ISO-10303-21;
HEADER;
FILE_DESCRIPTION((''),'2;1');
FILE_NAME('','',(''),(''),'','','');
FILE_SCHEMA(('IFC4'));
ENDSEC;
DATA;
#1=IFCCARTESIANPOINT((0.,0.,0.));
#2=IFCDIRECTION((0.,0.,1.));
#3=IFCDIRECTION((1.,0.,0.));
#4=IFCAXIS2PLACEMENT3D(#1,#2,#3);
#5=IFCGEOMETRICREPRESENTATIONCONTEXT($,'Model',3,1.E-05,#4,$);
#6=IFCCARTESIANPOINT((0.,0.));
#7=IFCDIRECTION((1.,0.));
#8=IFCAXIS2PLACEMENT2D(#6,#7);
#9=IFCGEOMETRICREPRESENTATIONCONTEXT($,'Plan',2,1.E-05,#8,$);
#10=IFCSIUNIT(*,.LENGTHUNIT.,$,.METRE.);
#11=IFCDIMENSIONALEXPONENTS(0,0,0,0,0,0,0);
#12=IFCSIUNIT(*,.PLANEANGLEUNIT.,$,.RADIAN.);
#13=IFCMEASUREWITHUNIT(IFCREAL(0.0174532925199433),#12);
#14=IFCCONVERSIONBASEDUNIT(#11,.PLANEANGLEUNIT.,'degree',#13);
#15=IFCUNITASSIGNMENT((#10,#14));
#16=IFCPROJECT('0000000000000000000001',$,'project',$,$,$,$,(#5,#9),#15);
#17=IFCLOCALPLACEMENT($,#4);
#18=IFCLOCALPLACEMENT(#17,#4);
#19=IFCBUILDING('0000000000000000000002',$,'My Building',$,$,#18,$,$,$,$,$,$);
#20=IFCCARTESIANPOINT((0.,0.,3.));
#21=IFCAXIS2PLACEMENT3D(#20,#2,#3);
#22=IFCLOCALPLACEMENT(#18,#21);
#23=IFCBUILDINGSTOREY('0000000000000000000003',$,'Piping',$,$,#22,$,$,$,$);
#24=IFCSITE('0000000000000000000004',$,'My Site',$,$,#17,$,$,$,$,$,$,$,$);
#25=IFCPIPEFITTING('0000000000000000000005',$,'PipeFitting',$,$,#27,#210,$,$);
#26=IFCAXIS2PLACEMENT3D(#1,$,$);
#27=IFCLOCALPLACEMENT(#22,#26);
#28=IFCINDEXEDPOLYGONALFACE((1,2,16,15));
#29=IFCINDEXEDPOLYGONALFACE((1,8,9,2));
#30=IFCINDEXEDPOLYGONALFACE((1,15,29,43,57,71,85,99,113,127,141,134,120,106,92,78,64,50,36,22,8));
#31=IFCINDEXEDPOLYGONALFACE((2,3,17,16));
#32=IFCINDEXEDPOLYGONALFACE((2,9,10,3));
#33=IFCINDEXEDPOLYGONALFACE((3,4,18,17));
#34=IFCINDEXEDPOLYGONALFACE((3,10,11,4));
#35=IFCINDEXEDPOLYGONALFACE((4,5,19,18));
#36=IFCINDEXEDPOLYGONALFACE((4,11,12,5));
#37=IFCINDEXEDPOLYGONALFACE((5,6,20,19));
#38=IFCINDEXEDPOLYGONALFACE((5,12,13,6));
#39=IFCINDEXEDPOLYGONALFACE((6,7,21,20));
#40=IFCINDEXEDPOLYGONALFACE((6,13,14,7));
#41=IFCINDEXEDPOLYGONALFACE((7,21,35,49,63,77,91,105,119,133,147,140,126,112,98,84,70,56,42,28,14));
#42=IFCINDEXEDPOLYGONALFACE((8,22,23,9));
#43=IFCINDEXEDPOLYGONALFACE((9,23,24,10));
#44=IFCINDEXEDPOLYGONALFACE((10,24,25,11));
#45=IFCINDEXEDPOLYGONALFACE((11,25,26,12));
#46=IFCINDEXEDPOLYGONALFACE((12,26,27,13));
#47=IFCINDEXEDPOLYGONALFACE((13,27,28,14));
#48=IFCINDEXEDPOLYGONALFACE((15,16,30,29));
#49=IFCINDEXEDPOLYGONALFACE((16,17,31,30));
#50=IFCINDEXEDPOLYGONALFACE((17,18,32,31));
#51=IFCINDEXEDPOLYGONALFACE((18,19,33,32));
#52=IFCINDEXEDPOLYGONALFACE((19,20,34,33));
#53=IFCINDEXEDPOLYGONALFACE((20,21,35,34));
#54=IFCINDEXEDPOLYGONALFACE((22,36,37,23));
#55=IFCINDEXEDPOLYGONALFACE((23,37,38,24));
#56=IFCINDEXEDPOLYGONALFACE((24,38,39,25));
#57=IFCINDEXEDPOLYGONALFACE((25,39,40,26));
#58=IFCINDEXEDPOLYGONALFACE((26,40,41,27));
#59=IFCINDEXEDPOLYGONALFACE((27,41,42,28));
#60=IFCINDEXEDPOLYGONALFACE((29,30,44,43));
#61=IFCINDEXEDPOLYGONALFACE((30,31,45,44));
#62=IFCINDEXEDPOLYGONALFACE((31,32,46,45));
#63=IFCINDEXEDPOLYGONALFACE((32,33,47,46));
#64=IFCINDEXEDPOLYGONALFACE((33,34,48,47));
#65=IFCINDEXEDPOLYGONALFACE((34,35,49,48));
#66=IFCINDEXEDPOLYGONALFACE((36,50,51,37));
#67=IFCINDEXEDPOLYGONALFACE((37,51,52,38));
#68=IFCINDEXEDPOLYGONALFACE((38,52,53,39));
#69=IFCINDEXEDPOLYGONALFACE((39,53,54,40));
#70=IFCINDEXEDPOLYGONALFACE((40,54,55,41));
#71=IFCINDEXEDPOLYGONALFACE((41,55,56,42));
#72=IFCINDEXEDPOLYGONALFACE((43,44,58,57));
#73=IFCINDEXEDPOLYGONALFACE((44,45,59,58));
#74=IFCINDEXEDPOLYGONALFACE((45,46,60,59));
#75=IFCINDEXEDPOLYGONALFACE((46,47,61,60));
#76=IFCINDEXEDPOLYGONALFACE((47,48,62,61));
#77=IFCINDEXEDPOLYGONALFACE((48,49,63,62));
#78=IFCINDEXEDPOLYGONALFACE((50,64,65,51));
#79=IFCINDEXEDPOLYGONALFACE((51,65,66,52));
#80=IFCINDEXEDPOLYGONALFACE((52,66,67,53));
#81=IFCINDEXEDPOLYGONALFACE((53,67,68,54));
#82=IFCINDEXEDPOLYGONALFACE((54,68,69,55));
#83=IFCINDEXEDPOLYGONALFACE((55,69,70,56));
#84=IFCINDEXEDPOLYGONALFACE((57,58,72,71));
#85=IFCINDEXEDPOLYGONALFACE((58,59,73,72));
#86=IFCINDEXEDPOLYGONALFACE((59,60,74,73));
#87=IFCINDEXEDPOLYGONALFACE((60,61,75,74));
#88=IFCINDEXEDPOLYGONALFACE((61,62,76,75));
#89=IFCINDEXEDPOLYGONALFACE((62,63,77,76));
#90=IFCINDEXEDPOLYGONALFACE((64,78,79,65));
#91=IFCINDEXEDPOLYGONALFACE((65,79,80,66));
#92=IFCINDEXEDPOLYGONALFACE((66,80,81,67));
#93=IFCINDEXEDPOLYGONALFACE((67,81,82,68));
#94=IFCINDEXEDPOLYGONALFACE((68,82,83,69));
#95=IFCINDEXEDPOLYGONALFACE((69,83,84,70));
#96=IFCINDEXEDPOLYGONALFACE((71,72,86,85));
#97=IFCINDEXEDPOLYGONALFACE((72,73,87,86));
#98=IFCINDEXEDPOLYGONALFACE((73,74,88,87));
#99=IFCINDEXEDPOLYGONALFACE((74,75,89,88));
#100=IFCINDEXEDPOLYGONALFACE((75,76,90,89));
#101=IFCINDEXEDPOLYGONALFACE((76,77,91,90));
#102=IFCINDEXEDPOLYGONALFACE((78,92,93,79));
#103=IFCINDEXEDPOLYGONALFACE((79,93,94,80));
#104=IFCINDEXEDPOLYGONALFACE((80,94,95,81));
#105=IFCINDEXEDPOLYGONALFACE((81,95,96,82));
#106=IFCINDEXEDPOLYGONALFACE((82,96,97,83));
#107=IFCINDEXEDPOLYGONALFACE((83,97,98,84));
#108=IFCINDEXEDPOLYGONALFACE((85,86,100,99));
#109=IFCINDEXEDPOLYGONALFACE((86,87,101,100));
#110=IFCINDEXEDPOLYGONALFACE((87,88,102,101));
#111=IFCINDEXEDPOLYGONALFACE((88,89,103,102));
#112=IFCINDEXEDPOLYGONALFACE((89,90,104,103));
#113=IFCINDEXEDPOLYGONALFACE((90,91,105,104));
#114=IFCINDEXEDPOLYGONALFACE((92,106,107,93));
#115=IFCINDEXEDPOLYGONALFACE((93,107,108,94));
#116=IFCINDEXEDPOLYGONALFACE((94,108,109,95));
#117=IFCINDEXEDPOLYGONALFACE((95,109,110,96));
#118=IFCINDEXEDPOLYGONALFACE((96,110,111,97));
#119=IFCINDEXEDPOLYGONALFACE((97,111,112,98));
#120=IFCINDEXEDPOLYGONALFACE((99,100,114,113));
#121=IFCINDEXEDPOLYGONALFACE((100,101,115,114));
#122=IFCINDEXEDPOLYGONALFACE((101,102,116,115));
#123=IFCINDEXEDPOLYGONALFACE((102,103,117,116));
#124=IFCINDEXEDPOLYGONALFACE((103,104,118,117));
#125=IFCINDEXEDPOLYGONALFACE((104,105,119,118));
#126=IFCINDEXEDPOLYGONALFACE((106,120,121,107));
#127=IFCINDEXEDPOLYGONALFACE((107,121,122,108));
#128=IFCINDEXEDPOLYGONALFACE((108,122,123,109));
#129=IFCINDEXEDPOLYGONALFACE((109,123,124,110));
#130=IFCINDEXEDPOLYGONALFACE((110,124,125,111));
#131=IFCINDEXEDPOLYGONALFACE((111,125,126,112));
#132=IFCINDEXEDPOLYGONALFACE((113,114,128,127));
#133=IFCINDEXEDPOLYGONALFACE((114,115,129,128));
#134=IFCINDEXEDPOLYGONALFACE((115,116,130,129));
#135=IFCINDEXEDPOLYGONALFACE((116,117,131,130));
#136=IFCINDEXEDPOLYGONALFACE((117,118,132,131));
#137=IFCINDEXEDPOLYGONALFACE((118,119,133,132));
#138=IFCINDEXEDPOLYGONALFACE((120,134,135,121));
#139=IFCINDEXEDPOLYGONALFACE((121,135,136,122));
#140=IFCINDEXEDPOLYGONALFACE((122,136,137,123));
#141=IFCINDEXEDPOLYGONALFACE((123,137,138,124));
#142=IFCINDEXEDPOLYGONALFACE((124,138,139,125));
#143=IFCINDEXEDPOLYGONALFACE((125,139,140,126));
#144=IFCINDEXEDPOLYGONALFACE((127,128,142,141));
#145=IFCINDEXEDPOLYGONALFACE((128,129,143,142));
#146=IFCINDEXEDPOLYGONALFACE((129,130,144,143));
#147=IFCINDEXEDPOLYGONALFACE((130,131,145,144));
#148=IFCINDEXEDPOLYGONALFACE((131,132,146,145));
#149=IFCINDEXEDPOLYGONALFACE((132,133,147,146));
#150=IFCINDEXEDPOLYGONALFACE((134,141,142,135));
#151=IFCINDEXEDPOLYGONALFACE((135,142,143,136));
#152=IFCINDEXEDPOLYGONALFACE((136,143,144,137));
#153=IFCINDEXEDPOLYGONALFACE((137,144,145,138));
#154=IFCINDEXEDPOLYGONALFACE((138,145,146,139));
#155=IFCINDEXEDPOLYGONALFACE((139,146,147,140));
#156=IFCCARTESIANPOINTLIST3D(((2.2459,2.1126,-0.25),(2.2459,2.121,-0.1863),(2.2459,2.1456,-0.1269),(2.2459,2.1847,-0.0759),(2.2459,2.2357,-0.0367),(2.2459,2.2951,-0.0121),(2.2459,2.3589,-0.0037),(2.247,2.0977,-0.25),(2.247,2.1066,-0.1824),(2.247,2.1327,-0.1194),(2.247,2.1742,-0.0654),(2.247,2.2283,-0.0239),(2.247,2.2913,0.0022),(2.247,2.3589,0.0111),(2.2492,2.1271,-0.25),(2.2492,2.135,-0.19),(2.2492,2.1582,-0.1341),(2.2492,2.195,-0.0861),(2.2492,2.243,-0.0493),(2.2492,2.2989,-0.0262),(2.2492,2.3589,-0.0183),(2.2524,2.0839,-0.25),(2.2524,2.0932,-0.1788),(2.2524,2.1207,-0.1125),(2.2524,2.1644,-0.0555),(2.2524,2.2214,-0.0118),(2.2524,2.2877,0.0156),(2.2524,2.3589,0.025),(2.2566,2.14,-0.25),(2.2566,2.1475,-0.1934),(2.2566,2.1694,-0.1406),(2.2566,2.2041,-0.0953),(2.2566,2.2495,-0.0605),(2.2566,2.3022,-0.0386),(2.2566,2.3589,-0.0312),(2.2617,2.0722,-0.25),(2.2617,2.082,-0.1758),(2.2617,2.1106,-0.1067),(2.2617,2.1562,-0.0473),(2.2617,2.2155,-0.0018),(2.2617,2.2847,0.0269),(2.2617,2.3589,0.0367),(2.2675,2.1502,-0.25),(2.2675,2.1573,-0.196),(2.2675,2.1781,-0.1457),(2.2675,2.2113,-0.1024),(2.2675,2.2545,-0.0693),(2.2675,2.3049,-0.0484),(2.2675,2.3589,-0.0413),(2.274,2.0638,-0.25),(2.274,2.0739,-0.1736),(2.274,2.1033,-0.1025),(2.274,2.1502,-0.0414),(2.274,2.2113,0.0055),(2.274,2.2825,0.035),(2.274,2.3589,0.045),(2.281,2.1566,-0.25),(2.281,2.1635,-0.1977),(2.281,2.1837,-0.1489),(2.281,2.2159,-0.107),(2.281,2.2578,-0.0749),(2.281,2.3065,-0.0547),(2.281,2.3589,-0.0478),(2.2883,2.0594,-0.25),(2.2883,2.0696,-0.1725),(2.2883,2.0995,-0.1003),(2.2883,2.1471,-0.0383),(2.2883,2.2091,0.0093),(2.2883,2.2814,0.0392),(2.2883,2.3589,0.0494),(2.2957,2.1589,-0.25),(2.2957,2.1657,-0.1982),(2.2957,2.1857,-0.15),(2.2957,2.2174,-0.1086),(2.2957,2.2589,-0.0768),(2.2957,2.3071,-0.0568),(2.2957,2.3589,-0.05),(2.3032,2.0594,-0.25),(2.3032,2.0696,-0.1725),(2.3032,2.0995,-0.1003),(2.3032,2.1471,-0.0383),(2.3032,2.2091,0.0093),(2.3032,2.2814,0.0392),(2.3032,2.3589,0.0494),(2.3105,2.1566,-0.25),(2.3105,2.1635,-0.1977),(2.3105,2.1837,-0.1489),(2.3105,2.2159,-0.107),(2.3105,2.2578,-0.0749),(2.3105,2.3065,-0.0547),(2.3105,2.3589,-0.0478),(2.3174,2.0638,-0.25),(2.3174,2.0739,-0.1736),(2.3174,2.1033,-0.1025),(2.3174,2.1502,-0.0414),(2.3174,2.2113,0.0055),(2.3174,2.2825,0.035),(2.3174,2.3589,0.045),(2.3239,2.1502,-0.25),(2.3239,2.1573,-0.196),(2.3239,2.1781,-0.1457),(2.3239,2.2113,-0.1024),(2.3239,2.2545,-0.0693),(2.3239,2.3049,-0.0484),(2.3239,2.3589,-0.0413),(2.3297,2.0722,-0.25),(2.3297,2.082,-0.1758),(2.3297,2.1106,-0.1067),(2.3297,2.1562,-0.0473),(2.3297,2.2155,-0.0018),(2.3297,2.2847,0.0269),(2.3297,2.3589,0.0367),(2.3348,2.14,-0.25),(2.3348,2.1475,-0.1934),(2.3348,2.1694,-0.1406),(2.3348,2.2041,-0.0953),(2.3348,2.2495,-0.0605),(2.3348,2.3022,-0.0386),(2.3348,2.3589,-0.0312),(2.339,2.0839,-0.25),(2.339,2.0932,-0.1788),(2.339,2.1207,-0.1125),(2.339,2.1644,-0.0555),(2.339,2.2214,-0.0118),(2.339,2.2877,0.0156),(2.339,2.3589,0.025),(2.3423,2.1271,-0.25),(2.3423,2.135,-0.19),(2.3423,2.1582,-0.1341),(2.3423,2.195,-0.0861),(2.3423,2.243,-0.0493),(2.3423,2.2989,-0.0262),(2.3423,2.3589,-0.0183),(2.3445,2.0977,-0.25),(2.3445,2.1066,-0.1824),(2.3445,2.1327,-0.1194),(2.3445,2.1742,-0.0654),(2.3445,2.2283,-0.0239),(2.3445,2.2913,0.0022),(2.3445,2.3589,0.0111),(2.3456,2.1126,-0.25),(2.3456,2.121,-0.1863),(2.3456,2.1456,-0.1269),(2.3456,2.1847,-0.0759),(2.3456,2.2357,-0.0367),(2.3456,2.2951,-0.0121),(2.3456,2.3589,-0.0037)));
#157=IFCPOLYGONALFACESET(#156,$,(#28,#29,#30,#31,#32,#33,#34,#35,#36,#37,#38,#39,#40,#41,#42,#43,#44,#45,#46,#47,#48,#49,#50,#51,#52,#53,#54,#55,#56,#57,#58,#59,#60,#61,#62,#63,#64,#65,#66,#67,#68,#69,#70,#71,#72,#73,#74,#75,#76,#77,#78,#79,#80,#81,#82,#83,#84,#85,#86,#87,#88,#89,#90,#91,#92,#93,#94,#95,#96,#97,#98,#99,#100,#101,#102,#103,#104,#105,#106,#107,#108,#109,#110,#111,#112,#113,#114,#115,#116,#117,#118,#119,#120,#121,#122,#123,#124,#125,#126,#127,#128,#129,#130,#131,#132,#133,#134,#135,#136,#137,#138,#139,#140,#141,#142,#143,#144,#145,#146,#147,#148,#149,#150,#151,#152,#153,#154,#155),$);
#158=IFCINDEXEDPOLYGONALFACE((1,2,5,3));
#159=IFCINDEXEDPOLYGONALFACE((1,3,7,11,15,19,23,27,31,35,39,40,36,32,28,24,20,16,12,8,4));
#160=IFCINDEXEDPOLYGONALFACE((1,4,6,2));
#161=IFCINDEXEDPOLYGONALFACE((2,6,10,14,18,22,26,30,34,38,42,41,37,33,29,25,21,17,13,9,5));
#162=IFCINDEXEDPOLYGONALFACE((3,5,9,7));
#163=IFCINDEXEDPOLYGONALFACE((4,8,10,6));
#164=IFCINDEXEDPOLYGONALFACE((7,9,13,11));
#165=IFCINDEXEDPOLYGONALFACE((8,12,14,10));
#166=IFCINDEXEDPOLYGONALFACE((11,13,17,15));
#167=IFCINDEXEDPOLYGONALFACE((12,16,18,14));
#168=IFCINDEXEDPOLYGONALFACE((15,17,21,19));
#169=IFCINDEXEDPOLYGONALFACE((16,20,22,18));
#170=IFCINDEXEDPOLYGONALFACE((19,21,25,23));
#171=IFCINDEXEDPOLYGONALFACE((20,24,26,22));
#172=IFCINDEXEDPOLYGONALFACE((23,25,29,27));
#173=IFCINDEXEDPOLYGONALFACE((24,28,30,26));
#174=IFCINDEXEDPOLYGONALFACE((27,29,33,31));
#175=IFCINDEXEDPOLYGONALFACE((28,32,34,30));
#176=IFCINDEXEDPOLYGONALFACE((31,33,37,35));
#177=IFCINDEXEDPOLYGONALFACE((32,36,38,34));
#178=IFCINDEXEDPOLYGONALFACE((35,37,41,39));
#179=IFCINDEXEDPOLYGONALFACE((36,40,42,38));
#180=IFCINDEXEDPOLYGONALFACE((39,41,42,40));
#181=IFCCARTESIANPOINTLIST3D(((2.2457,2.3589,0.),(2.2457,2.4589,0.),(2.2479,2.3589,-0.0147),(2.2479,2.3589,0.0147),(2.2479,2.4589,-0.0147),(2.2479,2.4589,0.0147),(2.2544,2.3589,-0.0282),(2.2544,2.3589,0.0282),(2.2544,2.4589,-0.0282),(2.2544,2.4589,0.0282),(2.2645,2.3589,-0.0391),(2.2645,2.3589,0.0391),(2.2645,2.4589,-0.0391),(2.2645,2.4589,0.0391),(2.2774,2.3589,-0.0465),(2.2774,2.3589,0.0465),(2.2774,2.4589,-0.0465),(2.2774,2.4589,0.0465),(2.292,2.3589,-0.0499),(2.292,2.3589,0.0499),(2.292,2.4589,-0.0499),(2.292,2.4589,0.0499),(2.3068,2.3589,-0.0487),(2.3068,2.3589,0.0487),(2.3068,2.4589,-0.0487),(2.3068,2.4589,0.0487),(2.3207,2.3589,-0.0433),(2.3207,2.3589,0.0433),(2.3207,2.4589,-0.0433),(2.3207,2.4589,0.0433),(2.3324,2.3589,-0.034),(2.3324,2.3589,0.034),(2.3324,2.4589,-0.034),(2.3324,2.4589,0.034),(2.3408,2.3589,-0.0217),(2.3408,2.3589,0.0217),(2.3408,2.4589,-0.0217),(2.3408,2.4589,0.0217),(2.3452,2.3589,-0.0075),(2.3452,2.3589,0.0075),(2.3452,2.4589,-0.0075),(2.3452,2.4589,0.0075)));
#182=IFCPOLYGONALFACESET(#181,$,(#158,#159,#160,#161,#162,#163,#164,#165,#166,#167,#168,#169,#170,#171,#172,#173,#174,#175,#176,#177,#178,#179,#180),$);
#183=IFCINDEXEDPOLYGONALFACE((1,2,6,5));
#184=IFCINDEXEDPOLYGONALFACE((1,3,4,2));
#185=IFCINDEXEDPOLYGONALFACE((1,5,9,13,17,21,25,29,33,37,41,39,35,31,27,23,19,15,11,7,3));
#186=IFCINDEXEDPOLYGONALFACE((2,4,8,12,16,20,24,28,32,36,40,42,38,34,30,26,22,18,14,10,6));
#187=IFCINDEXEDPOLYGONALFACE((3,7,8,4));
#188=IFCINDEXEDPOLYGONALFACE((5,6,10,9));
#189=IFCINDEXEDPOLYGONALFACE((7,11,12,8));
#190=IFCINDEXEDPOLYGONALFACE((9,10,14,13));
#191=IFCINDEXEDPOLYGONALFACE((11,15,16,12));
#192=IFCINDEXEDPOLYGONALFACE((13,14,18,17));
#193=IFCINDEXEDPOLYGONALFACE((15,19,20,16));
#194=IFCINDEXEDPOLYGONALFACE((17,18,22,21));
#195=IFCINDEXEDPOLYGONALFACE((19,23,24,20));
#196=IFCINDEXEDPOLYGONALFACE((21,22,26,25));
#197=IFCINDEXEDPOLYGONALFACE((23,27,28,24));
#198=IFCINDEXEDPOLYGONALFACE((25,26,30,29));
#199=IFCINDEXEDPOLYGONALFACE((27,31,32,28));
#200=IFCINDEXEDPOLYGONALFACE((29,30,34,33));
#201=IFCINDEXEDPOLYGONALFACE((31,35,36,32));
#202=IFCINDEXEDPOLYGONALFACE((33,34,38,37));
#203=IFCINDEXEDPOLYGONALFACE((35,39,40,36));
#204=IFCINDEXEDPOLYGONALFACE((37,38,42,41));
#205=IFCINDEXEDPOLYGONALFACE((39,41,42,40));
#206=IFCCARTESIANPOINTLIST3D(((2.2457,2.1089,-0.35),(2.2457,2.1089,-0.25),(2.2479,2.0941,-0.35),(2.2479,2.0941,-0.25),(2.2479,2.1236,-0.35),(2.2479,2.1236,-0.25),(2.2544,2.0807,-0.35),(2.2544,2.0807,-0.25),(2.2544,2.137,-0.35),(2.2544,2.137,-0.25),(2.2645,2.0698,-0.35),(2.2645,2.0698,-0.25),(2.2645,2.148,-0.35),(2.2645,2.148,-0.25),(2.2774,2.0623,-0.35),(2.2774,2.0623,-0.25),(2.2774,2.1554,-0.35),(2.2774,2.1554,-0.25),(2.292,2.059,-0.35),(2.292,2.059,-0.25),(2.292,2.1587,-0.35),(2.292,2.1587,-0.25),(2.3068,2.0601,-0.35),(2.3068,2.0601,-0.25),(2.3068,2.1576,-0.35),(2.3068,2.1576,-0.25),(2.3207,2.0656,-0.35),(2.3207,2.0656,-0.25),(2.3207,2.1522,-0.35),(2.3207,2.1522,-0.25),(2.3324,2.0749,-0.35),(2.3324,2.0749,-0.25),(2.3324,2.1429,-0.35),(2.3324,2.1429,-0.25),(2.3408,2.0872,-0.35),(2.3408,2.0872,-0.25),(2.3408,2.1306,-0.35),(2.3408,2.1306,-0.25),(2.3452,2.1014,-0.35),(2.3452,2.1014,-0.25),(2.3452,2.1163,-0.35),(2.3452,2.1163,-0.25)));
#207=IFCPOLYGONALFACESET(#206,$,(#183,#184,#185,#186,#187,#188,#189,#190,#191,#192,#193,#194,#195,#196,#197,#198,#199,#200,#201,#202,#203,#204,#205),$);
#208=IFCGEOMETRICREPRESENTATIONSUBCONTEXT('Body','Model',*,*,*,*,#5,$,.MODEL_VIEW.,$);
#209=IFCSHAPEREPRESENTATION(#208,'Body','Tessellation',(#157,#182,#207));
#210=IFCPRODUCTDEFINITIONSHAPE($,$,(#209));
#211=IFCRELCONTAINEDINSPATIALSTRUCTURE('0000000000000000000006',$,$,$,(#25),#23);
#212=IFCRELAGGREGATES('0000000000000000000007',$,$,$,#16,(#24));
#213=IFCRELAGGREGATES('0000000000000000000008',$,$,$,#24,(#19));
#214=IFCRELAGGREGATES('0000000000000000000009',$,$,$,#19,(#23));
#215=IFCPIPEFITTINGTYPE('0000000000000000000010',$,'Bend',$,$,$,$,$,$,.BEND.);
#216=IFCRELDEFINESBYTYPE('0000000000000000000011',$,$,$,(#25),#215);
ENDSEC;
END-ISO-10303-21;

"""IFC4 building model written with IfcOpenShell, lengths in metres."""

from ifc_helpers import new_model, entity, si_unit, converted_unit, frame, origin_with_axes, origin_2d_with_axis, place, context, subcontext, project, spatial, line, indexed_curve, circle, outline, extrude, source, transform, mapped, type_object, type_shapes, element, save


model = new_model("IFC4")

# Units and contexts
model_context = context("Model", 3, precision=1e-05, world=origin_with_axes())
plan_context = context("Plan", 2, precision=1e-05, world=origin_2d_with_axis())
body_context = subcontext(model_context, "Body", "Model", "MODEL_VIEW")
ifc_project = project(units=[si_unit("LENGTHUNIT", "METRE"), converted_unit("PLANEANGLEUNIT", "degree", entity("IfcReal", 0.0174532925199433), si_unit("PLANEANGLEUNIT", "RADIAN"), dimensions=[0, 0, 0, 0, 0, 0, 0])], contexts=[model_context, plan_context])

# Site, building, storey
site_placement = place(None, origin_with_axes())
site = spatial("IfcSite", under=ifc_project, at=site_placement, Name="My Site")
building_placement = place(site_placement, origin_with_axes())
building = spatial("IfcBuilding", under=site, at=building_placement, Name="My Building")
storey_placement = place(building_placement, frame((0.0, 0.0, 3.0), z_axis=(0.0, 0.0, 1.0), x_axis=(1.0, 0.0, 0.0)))
storey = spatial("IfcBuildingStorey", under=building, at=storey_placement, Name="Piping")

# Pipe fitting, opening
pipe_fitting_type = type_object("IfcPipeFittingType", Name="Bend", PredefinedType="BEND")
shared_shape = source(origin_with_axes(), body_context, "Body", "SolidModel", [
    entity("IfcSweptDiskSolid", entity("IfcIndexedPolyCurve", entity("IfcCartesianPointList3D", [[0.0, 0.0, -0.1], [0.0, -0.0732, -0.2768], [0.0, -0.25, -0.35]]), [entity("IfcArcIndex", [1, 2, 3])]), 0.05),
    extrude(circle(Radius=0.05), origin_with_axes(), (0.0, 0.0, -1.0), 0.1),
    extrude(circle(Radius=0.05), frame((0.0, -0.25, -0.35), z_axis=(0.0, -1.0, 0.0), x_axis=(1.0, 0.0, 0.0)), (0.0, 0.0, 1.0), 0.1),
])
type_shapes(pipe_fitting_type, [shared_shape])
pipe_fitting_1_placement = place(storey_placement, frame((2.2957, 2.4589, 0.0), z_axis=(0.0, 1.0, 0.0), x_axis=(-1.0, 0.0, 0.0)))
pipe_fitting_1 = element("IfcPipeFitting", 1, at=pipe_fitting_1_placement, inside=storey, type_object=pipe_fitting_type, Name="PipeFitting", context=body_context, shape_type="MappedRepresentation", body=[
    mapped(shared_shape, transform((0.0, 0.0, 0.0), x_axis=(1.0, 0.0, 0.0), y_axis=(0.0, 1.0, 0.0), z_axis=(0.0, 0.0, 1.0), scale=1.0)),
])
opening_1_placement = place(pipe_fitting_1_placement, frame((2.2957, -3.0, -2.4589), z_axis=(0.0, 1.0, 0.0), x_axis=(-1.0, 0.0, 0.0)))
element("IfcOpeningElement", 2, at=opening_1_placement, cuts=pipe_fitting_1, PredefinedType="OPENING", context=body_context, shape_type="SweptSolid", body=[
    extrude(outline(indexed_curve([(0.0, 0.0), (0.5, 0.0), (0.5, 0.5), (0.0, 0.5)], segments=[line(1, 2, 3, 4, 1)])), origin_with_axes(), (0.0, 0.0, 1.0), 0.5),
])

save(model, "model.ifc")
